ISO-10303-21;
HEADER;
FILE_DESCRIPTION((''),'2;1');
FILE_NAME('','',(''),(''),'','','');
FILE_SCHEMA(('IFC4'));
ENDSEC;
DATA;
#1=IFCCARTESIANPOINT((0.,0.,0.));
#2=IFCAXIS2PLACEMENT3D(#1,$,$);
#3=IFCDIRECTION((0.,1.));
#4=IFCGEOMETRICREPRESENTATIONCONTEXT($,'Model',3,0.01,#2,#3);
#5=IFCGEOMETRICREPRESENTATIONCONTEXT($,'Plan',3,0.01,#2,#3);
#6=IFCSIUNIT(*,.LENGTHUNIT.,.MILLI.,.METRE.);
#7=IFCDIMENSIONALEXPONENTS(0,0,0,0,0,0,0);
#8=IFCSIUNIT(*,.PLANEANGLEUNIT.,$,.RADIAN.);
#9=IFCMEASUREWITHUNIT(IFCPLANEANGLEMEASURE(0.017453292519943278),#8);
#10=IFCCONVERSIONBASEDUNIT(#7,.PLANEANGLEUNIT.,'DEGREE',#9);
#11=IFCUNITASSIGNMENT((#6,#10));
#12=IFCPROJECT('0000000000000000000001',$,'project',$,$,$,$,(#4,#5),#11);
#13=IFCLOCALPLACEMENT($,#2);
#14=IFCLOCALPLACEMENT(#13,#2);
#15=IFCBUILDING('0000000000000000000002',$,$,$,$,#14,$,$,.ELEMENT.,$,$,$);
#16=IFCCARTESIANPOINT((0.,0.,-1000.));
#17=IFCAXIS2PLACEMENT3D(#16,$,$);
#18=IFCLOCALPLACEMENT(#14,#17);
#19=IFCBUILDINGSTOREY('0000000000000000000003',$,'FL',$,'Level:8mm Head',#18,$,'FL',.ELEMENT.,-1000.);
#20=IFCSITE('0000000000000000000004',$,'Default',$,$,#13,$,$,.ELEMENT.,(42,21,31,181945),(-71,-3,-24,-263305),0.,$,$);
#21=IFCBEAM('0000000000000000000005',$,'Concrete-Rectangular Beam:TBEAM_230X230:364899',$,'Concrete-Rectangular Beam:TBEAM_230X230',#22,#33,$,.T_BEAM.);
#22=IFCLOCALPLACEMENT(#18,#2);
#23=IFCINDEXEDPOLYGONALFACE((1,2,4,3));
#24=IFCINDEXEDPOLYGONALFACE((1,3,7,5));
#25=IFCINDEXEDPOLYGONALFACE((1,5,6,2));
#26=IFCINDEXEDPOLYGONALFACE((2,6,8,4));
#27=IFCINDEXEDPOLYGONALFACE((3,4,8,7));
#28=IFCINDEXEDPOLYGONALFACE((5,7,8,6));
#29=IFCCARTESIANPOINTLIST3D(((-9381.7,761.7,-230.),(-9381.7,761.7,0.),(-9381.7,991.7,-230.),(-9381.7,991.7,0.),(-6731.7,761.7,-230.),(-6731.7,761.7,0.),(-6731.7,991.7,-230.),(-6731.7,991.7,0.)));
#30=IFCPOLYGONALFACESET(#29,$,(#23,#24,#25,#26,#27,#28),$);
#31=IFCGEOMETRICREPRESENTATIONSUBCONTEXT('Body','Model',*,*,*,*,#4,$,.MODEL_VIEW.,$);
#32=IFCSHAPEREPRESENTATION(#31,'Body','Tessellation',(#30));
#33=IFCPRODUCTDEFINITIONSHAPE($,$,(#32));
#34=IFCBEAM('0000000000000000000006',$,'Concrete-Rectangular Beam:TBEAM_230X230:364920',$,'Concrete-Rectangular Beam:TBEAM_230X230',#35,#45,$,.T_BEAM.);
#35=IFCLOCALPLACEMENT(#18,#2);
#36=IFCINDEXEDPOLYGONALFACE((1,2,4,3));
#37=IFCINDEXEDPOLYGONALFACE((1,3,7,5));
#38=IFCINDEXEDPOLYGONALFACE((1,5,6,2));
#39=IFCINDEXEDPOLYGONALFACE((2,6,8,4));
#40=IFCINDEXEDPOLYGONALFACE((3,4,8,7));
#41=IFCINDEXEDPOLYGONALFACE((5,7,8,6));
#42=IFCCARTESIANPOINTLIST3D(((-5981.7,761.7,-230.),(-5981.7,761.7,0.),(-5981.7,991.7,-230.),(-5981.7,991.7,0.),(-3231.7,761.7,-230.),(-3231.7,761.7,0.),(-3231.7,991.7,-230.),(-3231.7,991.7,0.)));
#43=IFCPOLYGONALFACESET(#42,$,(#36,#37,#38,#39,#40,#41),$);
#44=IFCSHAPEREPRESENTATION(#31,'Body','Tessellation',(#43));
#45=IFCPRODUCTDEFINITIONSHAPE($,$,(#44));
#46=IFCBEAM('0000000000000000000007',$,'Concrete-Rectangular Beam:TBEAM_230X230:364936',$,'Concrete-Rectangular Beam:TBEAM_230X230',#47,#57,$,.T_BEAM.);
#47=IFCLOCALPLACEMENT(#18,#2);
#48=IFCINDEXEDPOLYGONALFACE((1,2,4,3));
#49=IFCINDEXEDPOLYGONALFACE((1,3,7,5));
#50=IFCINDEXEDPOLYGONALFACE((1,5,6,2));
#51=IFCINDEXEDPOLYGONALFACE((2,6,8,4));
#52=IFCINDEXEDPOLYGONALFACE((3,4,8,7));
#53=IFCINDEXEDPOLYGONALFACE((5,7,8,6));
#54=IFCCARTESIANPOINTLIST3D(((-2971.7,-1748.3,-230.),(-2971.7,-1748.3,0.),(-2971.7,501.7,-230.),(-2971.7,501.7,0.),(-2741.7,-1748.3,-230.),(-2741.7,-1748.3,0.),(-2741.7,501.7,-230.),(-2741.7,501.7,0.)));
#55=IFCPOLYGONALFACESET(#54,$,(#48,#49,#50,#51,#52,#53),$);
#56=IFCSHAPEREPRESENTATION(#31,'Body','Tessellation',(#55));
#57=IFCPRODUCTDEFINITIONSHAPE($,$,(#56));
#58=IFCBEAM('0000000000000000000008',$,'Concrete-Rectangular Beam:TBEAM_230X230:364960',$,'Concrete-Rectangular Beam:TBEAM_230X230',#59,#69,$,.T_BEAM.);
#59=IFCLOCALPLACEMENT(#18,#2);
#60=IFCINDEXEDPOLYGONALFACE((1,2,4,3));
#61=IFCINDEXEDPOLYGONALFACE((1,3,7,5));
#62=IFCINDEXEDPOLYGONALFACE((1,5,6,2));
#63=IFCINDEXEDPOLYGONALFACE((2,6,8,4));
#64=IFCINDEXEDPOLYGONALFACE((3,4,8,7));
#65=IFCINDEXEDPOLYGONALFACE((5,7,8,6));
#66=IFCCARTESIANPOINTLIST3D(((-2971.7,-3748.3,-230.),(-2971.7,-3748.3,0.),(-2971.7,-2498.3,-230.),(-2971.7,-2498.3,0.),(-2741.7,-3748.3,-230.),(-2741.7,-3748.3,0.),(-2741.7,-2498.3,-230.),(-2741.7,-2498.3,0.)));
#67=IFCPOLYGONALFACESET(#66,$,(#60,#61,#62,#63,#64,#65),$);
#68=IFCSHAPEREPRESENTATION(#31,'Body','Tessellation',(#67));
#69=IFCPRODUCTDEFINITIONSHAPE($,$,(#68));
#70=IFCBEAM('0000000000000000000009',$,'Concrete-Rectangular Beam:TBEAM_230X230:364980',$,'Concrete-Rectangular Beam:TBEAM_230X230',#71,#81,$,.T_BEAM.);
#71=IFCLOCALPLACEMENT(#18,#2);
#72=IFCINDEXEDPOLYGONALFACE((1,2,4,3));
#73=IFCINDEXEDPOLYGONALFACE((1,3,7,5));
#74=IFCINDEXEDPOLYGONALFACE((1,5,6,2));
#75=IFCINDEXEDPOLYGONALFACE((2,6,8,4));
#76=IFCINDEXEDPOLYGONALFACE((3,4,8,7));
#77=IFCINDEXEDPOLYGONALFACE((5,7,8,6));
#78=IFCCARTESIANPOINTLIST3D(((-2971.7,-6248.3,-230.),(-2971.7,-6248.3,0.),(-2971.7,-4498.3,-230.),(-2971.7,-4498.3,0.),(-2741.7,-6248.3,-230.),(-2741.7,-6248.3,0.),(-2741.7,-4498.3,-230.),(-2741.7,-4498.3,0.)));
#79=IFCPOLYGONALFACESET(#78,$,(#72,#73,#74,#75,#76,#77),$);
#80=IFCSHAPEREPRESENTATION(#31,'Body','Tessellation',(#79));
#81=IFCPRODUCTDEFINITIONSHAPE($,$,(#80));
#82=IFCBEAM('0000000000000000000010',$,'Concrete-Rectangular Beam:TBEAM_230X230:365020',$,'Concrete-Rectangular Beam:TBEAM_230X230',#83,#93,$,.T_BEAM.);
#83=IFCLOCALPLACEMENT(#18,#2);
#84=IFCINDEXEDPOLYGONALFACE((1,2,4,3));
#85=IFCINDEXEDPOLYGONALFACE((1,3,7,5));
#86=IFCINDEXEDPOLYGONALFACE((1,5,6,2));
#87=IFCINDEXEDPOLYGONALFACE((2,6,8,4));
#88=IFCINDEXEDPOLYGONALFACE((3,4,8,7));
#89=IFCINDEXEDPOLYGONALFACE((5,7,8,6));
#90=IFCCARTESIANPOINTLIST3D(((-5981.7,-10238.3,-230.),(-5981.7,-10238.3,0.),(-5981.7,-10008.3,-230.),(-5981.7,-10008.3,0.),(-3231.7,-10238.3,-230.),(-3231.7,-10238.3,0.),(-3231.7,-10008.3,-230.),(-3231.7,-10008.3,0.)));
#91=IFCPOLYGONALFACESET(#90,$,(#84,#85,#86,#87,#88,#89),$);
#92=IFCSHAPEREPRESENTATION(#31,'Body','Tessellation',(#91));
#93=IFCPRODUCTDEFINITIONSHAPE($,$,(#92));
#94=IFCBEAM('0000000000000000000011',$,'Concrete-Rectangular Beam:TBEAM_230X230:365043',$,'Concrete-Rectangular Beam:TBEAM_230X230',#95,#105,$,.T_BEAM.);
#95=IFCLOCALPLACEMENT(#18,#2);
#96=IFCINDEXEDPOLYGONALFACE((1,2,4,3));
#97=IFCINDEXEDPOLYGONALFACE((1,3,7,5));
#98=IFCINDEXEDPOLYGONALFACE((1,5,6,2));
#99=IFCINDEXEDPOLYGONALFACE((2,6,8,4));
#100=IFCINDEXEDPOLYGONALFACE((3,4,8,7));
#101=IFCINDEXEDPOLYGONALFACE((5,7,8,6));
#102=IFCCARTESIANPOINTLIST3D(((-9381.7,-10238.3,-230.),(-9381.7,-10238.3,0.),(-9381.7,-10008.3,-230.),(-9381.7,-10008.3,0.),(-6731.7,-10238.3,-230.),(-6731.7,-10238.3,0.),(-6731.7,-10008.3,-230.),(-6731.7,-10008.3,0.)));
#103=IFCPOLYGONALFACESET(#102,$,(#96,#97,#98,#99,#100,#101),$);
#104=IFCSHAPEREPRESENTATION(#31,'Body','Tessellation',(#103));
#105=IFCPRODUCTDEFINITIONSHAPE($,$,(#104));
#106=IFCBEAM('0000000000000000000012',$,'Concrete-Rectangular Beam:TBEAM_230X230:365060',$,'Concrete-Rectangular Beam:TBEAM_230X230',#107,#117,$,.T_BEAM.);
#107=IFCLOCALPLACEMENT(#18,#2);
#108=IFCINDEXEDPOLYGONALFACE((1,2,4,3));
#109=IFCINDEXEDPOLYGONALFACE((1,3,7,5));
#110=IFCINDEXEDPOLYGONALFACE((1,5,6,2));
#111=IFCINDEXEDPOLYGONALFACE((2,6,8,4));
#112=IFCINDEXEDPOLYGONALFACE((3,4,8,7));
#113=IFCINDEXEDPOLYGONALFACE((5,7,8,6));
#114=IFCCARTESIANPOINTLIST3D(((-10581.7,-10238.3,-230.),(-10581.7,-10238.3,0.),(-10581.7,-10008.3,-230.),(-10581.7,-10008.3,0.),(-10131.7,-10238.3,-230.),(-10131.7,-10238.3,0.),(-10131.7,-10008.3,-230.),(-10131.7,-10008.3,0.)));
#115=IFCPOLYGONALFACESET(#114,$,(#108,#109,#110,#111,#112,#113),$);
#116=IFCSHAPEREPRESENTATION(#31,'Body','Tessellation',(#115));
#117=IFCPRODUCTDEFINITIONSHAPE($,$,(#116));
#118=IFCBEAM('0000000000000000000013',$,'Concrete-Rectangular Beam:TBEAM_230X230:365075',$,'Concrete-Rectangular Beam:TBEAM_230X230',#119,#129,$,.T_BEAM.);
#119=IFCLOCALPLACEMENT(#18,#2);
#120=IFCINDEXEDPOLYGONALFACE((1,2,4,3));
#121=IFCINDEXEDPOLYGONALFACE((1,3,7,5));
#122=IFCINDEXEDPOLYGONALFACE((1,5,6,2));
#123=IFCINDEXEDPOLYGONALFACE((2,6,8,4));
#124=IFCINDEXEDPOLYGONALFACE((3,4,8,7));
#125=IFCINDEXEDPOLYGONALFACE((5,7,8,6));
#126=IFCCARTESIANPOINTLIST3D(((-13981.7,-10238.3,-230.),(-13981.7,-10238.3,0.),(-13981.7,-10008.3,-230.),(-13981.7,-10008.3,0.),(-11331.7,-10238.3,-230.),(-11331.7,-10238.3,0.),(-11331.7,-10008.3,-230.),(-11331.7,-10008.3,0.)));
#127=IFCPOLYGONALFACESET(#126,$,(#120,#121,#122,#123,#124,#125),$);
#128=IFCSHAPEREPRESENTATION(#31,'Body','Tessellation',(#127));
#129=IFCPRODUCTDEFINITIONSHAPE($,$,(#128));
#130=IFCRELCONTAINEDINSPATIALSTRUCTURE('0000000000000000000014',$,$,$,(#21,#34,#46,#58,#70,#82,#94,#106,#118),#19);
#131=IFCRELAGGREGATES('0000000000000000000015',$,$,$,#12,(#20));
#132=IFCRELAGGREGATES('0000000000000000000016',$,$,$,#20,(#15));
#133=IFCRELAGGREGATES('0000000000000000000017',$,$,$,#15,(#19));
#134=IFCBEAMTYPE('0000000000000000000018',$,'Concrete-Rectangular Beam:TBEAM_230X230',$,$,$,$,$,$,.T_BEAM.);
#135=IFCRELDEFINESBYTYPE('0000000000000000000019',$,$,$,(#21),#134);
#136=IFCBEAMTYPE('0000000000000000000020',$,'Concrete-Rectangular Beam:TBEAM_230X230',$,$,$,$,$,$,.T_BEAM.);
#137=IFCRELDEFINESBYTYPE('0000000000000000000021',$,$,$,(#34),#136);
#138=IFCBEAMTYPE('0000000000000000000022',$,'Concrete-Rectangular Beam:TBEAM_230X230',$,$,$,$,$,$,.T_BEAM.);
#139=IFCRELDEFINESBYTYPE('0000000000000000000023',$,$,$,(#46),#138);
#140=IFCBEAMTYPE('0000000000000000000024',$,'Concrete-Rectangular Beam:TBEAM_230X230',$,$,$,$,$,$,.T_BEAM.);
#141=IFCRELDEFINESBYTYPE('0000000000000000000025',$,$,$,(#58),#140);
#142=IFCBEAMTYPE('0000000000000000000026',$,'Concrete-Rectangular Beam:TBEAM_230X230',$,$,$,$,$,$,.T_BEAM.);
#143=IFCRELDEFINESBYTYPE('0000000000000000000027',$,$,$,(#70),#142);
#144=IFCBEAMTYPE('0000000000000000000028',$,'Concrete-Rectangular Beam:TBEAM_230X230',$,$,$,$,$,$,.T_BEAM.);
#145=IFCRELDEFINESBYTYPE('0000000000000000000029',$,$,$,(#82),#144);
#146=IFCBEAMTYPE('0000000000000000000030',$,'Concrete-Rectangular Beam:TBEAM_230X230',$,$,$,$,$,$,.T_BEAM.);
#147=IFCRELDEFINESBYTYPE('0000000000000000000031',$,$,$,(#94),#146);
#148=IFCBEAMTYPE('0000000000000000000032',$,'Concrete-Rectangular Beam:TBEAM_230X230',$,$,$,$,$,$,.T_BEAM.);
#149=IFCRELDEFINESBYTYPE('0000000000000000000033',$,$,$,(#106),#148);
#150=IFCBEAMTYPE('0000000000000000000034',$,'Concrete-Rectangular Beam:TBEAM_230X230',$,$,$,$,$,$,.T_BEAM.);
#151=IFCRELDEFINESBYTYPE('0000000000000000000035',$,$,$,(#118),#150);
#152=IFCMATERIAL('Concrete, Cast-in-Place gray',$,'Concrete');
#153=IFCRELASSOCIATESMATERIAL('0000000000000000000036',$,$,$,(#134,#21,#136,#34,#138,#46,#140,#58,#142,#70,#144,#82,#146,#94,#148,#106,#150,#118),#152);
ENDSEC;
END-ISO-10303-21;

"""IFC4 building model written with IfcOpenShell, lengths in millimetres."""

from ifc_helpers import new_model, entity, si_unit, converted_unit, direction, frame, origin, place, context, subcontext, project, spatial, indexed_curve, outline, extrude, source, transform, mapped, material, type_object, type_shapes, element, save


model = new_model("IFC4")

# Units and contexts
model_context = context("Model", 3, precision=0.01, world=origin(), true_north=direction((0.0, 1.0)))
plan_context = context("Plan", 3, precision=0.01, world=origin(), true_north=direction((0.0, 1.0)))
body_context = subcontext(model_context, "Body", "Model", "MODEL_VIEW")
ifc_project = project(units=[si_unit("LENGTHUNIT", "METRE", prefix="MILLI"), converted_unit("PLANEANGLEUNIT", "DEGREE", entity("IfcPlaneAngleMeasure", 0.017453292519943278), si_unit("PLANEANGLEUNIT", "RADIAN"), dimensions=[0, 0, 0, 0, 0, 0, 0])], contexts=[model_context, plan_context])

# Site, building, storey
site_placement = place(None, origin())
site = spatial("IfcSite", under=ifc_project, at=site_placement, Name="Default", CompositionType="ELEMENT", RefLatitude=(42, 21, 31, 181945), RefLongitude=(-71, -3, -24, -263305), RefElevation=0.0)
building_placement = place(site_placement, origin())
building = spatial("IfcBuilding", under=site, at=building_placement, CompositionType="ELEMENT")
storey_placement = place(building_placement, frame((0.0, 0.0, -1000.0)))
storey = spatial("IfcBuildingStorey", under=building, at=storey_placement, Name="FL", ObjectType="Level:8mm Head", LongName="FL", CompositionType="ELEMENT", Elevation=-1000.0)

# Shared definitions
ifc_material = material(Name="Concrete, Cast-in-Place gray", Category="Concrete")

# Beams
beam_type_1 = type_object("IfcBeamType", Name="Concrete-Rectangular Beam:TBEAM_230X230", PredefinedType="T_BEAM", material=ifc_material)
shared_shape_1 = source(origin(), body_context, "Body", "SweptSolid", [
    extrude(outline(indexed_curve([(-115.0, -115.0), (115.0, -115.0), (115.0, 115.0), (-115.0, 115.0), (-115.0, -115.0)], self_intersect=False)), frame((-9381.7, 876.7, -1115.0), z_axis=(1.0, 0.0, 0.0), x_axis=(0.0, 0.0, -1.0)), (0.0, 0.0, 1.0), 2650.0),
])
type_shapes(beam_type_1, [shared_shape_1])
beam_1_placement = place(storey_placement, frame((0.0, 0.0, 1000.0)))
element("IfcBeam", 1, at=beam_1_placement, inside=storey, type_object=beam_type_1, material=ifc_material, Name="Concrete-Rectangular Beam:TBEAM_230X230:364899", ObjectType="Concrete-Rectangular Beam:TBEAM_230X230", PredefinedType="T_BEAM", context=body_context, shape_type="MappedRepresentation", body=[
    mapped(shared_shape_1, transform((0.0, 0.0, 0.0), scale=1.0)),
])
beam_type_2 = type_object("IfcBeamType", Name="Concrete-Rectangular Beam:TBEAM_230X230", PredefinedType="T_BEAM", material=ifc_material)
shared_shape_2 = source(origin(), body_context, "Body", "SweptSolid", [
    extrude(outline(indexed_curve([(-115.0, -115.0), (115.0, -115.0), (115.0, 115.0), (-115.0, 115.0), (-115.0, -115.0)], self_intersect=False)), frame((-5981.7, 876.7, -1115.0), z_axis=(1.0, 0.0, 0.0), x_axis=(0.0, 0.0, -1.0)), (0.0, 0.0, 1.0), 2750.0),
])
type_shapes(beam_type_2, [shared_shape_2])
beam_2_placement = place(storey_placement, frame((0.0, 0.0, 1000.0)))
element("IfcBeam", 2, at=beam_2_placement, inside=storey, type_object=beam_type_2, material=ifc_material, Name="Concrete-Rectangular Beam:TBEAM_230X230:364920", ObjectType="Concrete-Rectangular Beam:TBEAM_230X230", PredefinedType="T_BEAM", context=body_context, shape_type="MappedRepresentation", body=[
    mapped(shared_shape_2, transform((0.0, 0.0, 0.0), scale=1.0)),
])
beam_type_3 = type_object("IfcBeamType", Name="Concrete-Rectangular Beam:TBEAM_230X230", PredefinedType="T_BEAM", material=ifc_material)
shared_shape_3 = source(origin(), body_context, "Body", "SweptSolid", [
    extrude(outline(indexed_curve([(-115.0, -115.0), (115.0, -115.0), (115.0, 115.0), (-115.0, 115.0), (-115.0, -115.0)], self_intersect=False)), frame((-2856.7, 501.7, -1115.0), z_axis=(0.0, -1.0, 0.0), x_axis=(-1.0, 0.0, 0.0)), (0.0, 0.0, 1.0), 2250.0),
])
type_shapes(beam_type_3, [shared_shape_3])
beam_3_placement = place(storey_placement, frame((0.0, 0.0, 1000.0)))
element("IfcBeam", 3, at=beam_3_placement, inside=storey, type_object=beam_type_3, material=ifc_material, Name="Concrete-Rectangular Beam:TBEAM_230X230:364936", ObjectType="Concrete-Rectangular Beam:TBEAM_230X230", PredefinedType="T_BEAM", context=body_context, shape_type="MappedRepresentation", body=[
    mapped(shared_shape_3, transform((0.0, 0.0, 0.0), scale=1.0)),
])
beam_type_4 = type_object("IfcBeamType", Name="Concrete-Rectangular Beam:TBEAM_230X230", PredefinedType="T_BEAM", material=ifc_material)
shared_shape_4 = source(origin(), body_context, "Body", "SweptSolid", [
    extrude(outline(indexed_curve([(-115.0, -115.0), (115.0, -115.0), (115.0, 115.0), (-115.0, 115.0), (-115.0, -115.0)], self_intersect=False)), frame((-2856.7, -2498.3, -1115.0), z_axis=(0.0, -1.0, 0.0), x_axis=(-1.0, 0.0, 0.0)), (0.0, 0.0, 1.0), 1250.0),
])
type_shapes(beam_type_4, [shared_shape_4])
beam_4_placement = place(storey_placement, frame((0.0, 0.0, 1000.0)))
element("IfcBeam", 4, at=beam_4_placement, inside=storey, type_object=beam_type_4, material=ifc_material, Name="Concrete-Rectangular Beam:TBEAM_230X230:364960", ObjectType="Concrete-Rectangular Beam:TBEAM_230X230", PredefinedType="T_BEAM", context=body_context, shape_type="MappedRepresentation", body=[
    mapped(shared_shape_4, transform((0.0, 0.0, 0.0), scale=1.0)),
])
beam_type_5 = type_object("IfcBeamType", Name="Concrete-Rectangular Beam:TBEAM_230X230", PredefinedType="T_BEAM", material=ifc_material)
shared_shape_5 = source(origin(), body_context, "Body", "SweptSolid", [
    extrude(outline(indexed_curve([(-115.0, -115.0), (115.0, -115.0), (115.0, 115.0), (-115.0, 115.0), (-115.0, -115.0)], self_intersect=False)), frame((-2856.7, -4498.3, -1115.0), z_axis=(0.0, -1.0, 0.0), x_axis=(-1.0, 0.0, 0.0)), (0.0, 0.0, 1.0), 1750.0),
])
type_shapes(beam_type_5, [shared_shape_5])
beam_5_placement = place(storey_placement, frame((0.0, 0.0, 1000.0)))
element("IfcBeam", 5, at=beam_5_placement, inside=storey, type_object=beam_type_5, material=ifc_material, Name="Concrete-Rectangular Beam:TBEAM_230X230:364980", ObjectType="Concrete-Rectangular Beam:TBEAM_230X230", PredefinedType="T_BEAM", context=body_context, shape_type="MappedRepresentation", body=[
    mapped(shared_shape_5, transform((0.0, 0.0, 0.0), scale=1.0)),
])
beam_type_6 = type_object("IfcBeamType", Name="Concrete-Rectangular Beam:TBEAM_230X230", PredefinedType="T_BEAM", material=ifc_material)
shared_shape_6 = source(origin(), body_context, "Body", "SweptSolid", [
    extrude(outline(indexed_curve([(-115.0, -115.0), (115.0, -115.0), (115.0, 115.0), (-115.0, 115.0), (-115.0, -115.0)], self_intersect=False)), frame((-3231.7, -10123.3, -1115.0), z_axis=(-1.0, 0.0, 0.0), x_axis=(0.0, 0.0, -1.0)), (0.0, 0.0, 1.0), 2750.0),
])
type_shapes(beam_type_6, [shared_shape_6])
beam_6_placement = place(storey_placement, frame((0.0, 0.0, 1000.0)))
element("IfcBeam", 6, at=beam_6_placement, inside=storey, type_object=beam_type_6, material=ifc_material, Name="Concrete-Rectangular Beam:TBEAM_230X230:365020", ObjectType="Concrete-Rectangular Beam:TBEAM_230X230", PredefinedType="T_BEAM", context=body_context, shape_type="MappedRepresentation", body=[
    mapped(shared_shape_6, transform((0.0, 0.0, 0.0), scale=1.0)),
])
beam_type_7 = type_object("IfcBeamType", Name="Concrete-Rectangular Beam:TBEAM_230X230", PredefinedType="T_BEAM", material=ifc_material)
shared_shape_7 = source(origin(), body_context, "Body", "SweptSolid", [
    extrude(outline(indexed_curve([(-115.0, -115.0), (115.0, -115.0), (115.0, 115.0), (-115.0, 115.0), (-115.0, -115.0)], self_intersect=False)), frame((-6731.7, -10123.3, -1115.0), z_axis=(-1.0, 0.0, 0.0), x_axis=(0.0, 0.0, -1.0)), (0.0, 0.0, 1.0), 2650.0),
])
type_shapes(beam_type_7, [shared_shape_7])
beam_7_placement = place(storey_placement, frame((0.0, 0.0, 1000.0)))
element("IfcBeam", 7, at=beam_7_placement, inside=storey, type_object=beam_type_7, material=ifc_material, Name="Concrete-Rectangular Beam:TBEAM_230X230:365043", ObjectType="Concrete-Rectangular Beam:TBEAM_230X230", PredefinedType="T_BEAM", context=body_context, shape_type="MappedRepresentation", body=[
    mapped(shared_shape_7, transform((0.0, 0.0, 0.0), scale=1.0)),
])
beam_type_8 = type_object("IfcBeamType", Name="Concrete-Rectangular Beam:TBEAM_230X230", PredefinedType="T_BEAM", material=ifc_material)
shared_shape_8 = source(origin(), body_context, "Body", "SweptSolid", [
    extrude(outline(indexed_curve([(-115.0, -115.0), (115.0, -115.0), (115.0, 115.0), (-115.0, 115.0), (-115.0, -115.0)], self_intersect=False)), frame((-10131.7, -10123.3, -1115.0), z_axis=(-1.0, 0.0, 0.0), x_axis=(0.0, 0.0, -1.0)), (0.0, 0.0, 1.0), 450.0),
])
type_shapes(beam_type_8, [shared_shape_8])
beam_8_placement = place(storey_placement, frame((0.0, 0.0, 1000.0)))
element("IfcBeam", 8, at=beam_8_placement, inside=storey, type_object=beam_type_8, material=ifc_material, Name="Concrete-Rectangular Beam:TBEAM_230X230:365060", ObjectType="Concrete-Rectangular Beam:TBEAM_230X230", PredefinedType="T_BEAM", context=body_context, shape_type="MappedRepresentation", body=[
    mapped(shared_shape_8, transform((0.0, 0.0, 0.0), scale=1.0)),
])
beam_type_9 = type_object("IfcBeamType", Name="Concrete-Rectangular Beam:TBEAM_230X230", PredefinedType="T_BEAM", material=ifc_material)
shared_shape_9 = source(origin(), body_context, "Body", "SweptSolid", [
    extrude(outline(indexed_curve([(-115.0, -115.0), (115.0, -115.0), (115.0, 115.0), (-115.0, 115.0), (-115.0, -115.0)], self_intersect=False)), frame((-11331.7, -10123.3, -1115.0), z_axis=(-1.0, 0.0, 0.0), x_axis=(0.0, 0.0, -1.0)), (0.0, 0.0, 1.0), 2650.0),
])
type_shapes(beam_type_9, [shared_shape_9])
beam_9_placement = place(storey_placement, frame((0.0, 0.0, 1000.0)))
element("IfcBeam", 9, at=beam_9_placement, inside=storey, type_object=beam_type_9, material=ifc_material, Name="Concrete-Rectangular Beam:TBEAM_230X230:365075", ObjectType="Concrete-Rectangular Beam:TBEAM_230X230", PredefinedType="T_BEAM", context=body_context, shape_type="MappedRepresentation", body=[
    mapped(shared_shape_9, transform((0.0, 0.0, 0.0), scale=1.0)),
])

save(model, "model.ifc")
